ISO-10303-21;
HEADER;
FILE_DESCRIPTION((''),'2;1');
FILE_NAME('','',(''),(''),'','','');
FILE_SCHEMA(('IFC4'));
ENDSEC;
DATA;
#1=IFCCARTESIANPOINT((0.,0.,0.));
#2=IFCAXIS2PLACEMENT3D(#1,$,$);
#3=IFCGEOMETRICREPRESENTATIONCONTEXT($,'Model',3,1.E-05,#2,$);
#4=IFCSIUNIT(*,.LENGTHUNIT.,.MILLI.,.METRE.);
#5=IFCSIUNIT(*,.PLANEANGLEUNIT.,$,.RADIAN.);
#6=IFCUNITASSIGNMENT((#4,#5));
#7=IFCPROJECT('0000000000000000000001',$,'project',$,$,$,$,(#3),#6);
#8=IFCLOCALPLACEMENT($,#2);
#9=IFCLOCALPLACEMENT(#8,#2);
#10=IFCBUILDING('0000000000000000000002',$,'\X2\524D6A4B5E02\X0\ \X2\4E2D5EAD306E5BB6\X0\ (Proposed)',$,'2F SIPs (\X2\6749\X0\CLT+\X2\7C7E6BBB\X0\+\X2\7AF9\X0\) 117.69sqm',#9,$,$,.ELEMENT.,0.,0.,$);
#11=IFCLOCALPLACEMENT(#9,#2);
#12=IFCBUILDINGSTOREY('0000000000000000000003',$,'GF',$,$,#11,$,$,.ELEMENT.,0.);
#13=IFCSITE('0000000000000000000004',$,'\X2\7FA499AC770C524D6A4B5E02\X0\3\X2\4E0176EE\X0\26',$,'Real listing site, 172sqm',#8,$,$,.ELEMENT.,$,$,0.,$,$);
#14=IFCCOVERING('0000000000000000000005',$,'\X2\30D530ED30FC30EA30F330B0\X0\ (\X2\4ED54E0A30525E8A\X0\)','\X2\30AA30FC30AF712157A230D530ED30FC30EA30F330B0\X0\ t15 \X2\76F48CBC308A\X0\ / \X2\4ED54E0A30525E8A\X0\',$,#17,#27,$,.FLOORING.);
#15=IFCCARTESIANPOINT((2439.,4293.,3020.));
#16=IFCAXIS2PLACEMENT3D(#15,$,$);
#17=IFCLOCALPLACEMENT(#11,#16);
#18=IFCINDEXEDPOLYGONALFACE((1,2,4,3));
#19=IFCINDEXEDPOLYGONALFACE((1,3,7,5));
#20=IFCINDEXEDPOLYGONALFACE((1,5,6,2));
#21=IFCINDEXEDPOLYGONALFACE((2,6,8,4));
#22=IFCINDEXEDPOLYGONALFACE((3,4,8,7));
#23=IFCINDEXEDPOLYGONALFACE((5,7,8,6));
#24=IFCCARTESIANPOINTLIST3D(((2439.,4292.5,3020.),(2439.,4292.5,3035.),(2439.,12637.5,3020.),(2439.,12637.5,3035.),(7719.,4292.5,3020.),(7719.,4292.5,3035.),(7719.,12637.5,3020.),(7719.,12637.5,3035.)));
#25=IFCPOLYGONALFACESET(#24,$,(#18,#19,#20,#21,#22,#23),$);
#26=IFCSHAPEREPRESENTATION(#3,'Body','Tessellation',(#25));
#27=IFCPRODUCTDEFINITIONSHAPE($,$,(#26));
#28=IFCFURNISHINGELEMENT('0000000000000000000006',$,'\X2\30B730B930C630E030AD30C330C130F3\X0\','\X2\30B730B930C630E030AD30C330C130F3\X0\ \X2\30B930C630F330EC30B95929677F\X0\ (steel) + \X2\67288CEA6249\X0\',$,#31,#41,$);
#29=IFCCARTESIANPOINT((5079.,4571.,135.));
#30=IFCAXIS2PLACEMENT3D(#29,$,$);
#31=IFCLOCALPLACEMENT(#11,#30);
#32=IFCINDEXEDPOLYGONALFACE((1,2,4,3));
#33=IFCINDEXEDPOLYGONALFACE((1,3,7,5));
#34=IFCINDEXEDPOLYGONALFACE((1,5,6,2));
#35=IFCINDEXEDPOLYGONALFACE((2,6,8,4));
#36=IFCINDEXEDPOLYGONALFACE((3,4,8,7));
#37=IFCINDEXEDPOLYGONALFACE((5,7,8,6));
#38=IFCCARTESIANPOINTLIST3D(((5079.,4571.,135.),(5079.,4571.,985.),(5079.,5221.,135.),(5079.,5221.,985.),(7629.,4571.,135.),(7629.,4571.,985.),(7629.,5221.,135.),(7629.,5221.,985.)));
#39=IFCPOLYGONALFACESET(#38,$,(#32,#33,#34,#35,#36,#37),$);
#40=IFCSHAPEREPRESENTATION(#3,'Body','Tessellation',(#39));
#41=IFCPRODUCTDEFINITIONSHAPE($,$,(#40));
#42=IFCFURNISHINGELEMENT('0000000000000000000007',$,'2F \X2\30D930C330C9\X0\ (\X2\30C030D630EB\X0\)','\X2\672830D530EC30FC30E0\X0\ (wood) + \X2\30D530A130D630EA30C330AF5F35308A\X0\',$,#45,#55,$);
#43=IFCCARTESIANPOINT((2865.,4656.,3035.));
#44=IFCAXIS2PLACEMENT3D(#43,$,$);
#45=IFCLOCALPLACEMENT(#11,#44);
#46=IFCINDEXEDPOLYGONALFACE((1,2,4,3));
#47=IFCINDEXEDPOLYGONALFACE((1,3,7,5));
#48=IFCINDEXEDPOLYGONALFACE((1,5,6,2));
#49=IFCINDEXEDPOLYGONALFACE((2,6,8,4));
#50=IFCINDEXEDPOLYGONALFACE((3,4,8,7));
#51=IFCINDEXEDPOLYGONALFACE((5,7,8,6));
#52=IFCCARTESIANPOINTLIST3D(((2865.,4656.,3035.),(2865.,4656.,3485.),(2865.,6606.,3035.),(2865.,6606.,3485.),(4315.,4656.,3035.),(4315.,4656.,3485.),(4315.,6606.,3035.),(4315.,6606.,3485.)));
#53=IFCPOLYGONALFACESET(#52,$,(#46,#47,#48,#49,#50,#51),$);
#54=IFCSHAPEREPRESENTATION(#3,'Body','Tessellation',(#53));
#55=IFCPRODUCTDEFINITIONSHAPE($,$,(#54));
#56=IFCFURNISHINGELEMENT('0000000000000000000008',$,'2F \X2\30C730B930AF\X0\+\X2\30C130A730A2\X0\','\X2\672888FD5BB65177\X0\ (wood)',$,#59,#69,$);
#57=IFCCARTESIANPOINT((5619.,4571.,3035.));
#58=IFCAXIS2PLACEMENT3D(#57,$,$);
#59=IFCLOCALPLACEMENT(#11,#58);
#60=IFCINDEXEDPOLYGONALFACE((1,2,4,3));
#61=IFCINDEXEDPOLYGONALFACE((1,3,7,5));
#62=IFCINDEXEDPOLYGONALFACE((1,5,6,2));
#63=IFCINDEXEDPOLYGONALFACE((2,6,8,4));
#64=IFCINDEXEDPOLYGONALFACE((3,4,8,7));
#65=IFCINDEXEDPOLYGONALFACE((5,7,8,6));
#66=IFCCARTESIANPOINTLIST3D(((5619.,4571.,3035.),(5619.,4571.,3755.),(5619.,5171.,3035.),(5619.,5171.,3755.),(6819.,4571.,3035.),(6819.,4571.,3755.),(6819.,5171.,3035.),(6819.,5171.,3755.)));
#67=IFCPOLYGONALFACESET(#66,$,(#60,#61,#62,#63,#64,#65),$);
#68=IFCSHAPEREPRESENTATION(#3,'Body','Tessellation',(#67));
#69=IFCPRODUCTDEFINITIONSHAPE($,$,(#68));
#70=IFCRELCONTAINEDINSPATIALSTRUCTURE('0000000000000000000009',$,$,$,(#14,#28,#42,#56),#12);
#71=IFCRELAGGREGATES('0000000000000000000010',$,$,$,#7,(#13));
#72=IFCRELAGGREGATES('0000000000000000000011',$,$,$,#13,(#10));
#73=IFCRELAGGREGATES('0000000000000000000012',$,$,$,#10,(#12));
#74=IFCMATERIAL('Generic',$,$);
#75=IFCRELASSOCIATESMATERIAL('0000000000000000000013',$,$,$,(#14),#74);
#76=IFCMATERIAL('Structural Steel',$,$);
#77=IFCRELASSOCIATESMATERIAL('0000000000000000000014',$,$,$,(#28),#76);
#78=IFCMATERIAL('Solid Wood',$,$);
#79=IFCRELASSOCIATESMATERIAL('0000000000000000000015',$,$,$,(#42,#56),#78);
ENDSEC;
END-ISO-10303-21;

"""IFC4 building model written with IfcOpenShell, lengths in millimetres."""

from ifc_helpers import new_model, si_unit, frame, frame_2d, origin, place, context, project, spatial, rectangle, extrude, material, element, save


model = new_model("IFC4")

# Units and contexts
model_context = context("Model", 3, precision=1e-05, world=origin())
ifc_project = project(units=[si_unit("LENGTHUNIT", "METRE", prefix="MILLI"), si_unit("PLANEANGLEUNIT", "RADIAN")], contexts=[model_context])

# Site, building, storey
site_placement = place(None, origin())
site = spatial("IfcSite", under=ifc_project, at=site_placement, Name="群馬県前橋市3丁目26", ObjectType="Real listing site, 172sqm", CompositionType="ELEMENT", RefElevation=0.0)
building_placement = place(site_placement, origin())
building = spatial("IfcBuilding", under=site, at=building_placement, Name="前橋市 中庭の家 (Proposed)", ObjectType="2F SIPs (杉CLT+籾殻+竹) 117.69sqm", CompositionType="ELEMENT", ElevationOfRefHeight=0.0, ElevationOfTerrain=0.0)
storey_placement = place(building_placement, origin())
storey = spatial("IfcBuildingStorey", under=building, at=storey_placement, Name="GF", CompositionType="ELEMENT", Elevation=0.0)

# Shared definitions
ifc_material_1 = material(Name="Solid Wood")

# Shared definitions
ifc_material_2 = material(Name="Generic")

# Shared definitions
ifc_material_3 = material(Name="Structural Steel")

# Covering
covering_placement = place(storey_placement, frame((2439.0, 4293.0, 3020.0)))
element("IfcCovering", 1, at=covering_placement, inside=storey, material=ifc_material_2, Name="フローリング (仕上げ床)", Description="オーク無垢フローリング t15 直貼り / 仕上げ床", PredefinedType="FLOORING", context=model_context, shape_type="SweptSolid", body=[
    extrude(rectangle(XDim=5280.0, YDim=8345.0, at=frame_2d((2640.0, 4172.0))), frame((2439.0, 4293.0, 3020.0)), (0.0, 0.0, 1.0), 15.0),
])

# Furnishing elements
furnishing_1_placement = place(storey_placement, frame((5079.0, 4571.0, 135.0)))
element("IfcFurnishingElement", 2, at=furnishing_1_placement, inside=storey, material=ifc_material_3, Name="システムキッチン", Description="システムキッチン ステンレス天板 (steel) + 木質扉", context=model_context, shape_type="SweptSolid", body=[
    extrude(rectangle(XDim=2550.0, YDim=650.0, at=frame_2d((1275.0, 325.0))), frame((5079.0, 4571.0, 135.0)), (0.0, 0.0, 1.0), 850.0),
])
furnishing_2_placement = place(storey_placement, frame((2865.0, 4656.0, 3035.0)))
element("IfcFurnishingElement", 3, at=furnishing_2_placement, inside=storey, material=ifc_material_1, Name="2F ベッド (ダブル)", Description="木フレーム (wood) + ファブリック張り", context=model_context, shape_type="SweptSolid", body=[
    extrude(rectangle(XDim=1450.0, YDim=1950.0, at=frame_2d((725.0, 975.0))), frame((2865.0, 4656.0, 3035.0)), (0.0, 0.0, 1.0), 450.0),
])
furnishing_3_placement = place(storey_placement, frame((5619.0, 4571.0, 3035.0)))
element("IfcFurnishingElement", 4, at=furnishing_3_placement, inside=storey, material=ifc_material_1, Name="2F デスク+チェア", Description="木製家具 (wood)", context=model_context, shape_type="SweptSolid", body=[
    extrude(rectangle(XDim=1200.0, YDim=600.0, at=frame_2d((600.0, 300.0))), frame((5619.0, 4571.0, 3035.0)), (0.0, 0.0, 1.0), 720.0),
])

save(model, "model.ifc")
